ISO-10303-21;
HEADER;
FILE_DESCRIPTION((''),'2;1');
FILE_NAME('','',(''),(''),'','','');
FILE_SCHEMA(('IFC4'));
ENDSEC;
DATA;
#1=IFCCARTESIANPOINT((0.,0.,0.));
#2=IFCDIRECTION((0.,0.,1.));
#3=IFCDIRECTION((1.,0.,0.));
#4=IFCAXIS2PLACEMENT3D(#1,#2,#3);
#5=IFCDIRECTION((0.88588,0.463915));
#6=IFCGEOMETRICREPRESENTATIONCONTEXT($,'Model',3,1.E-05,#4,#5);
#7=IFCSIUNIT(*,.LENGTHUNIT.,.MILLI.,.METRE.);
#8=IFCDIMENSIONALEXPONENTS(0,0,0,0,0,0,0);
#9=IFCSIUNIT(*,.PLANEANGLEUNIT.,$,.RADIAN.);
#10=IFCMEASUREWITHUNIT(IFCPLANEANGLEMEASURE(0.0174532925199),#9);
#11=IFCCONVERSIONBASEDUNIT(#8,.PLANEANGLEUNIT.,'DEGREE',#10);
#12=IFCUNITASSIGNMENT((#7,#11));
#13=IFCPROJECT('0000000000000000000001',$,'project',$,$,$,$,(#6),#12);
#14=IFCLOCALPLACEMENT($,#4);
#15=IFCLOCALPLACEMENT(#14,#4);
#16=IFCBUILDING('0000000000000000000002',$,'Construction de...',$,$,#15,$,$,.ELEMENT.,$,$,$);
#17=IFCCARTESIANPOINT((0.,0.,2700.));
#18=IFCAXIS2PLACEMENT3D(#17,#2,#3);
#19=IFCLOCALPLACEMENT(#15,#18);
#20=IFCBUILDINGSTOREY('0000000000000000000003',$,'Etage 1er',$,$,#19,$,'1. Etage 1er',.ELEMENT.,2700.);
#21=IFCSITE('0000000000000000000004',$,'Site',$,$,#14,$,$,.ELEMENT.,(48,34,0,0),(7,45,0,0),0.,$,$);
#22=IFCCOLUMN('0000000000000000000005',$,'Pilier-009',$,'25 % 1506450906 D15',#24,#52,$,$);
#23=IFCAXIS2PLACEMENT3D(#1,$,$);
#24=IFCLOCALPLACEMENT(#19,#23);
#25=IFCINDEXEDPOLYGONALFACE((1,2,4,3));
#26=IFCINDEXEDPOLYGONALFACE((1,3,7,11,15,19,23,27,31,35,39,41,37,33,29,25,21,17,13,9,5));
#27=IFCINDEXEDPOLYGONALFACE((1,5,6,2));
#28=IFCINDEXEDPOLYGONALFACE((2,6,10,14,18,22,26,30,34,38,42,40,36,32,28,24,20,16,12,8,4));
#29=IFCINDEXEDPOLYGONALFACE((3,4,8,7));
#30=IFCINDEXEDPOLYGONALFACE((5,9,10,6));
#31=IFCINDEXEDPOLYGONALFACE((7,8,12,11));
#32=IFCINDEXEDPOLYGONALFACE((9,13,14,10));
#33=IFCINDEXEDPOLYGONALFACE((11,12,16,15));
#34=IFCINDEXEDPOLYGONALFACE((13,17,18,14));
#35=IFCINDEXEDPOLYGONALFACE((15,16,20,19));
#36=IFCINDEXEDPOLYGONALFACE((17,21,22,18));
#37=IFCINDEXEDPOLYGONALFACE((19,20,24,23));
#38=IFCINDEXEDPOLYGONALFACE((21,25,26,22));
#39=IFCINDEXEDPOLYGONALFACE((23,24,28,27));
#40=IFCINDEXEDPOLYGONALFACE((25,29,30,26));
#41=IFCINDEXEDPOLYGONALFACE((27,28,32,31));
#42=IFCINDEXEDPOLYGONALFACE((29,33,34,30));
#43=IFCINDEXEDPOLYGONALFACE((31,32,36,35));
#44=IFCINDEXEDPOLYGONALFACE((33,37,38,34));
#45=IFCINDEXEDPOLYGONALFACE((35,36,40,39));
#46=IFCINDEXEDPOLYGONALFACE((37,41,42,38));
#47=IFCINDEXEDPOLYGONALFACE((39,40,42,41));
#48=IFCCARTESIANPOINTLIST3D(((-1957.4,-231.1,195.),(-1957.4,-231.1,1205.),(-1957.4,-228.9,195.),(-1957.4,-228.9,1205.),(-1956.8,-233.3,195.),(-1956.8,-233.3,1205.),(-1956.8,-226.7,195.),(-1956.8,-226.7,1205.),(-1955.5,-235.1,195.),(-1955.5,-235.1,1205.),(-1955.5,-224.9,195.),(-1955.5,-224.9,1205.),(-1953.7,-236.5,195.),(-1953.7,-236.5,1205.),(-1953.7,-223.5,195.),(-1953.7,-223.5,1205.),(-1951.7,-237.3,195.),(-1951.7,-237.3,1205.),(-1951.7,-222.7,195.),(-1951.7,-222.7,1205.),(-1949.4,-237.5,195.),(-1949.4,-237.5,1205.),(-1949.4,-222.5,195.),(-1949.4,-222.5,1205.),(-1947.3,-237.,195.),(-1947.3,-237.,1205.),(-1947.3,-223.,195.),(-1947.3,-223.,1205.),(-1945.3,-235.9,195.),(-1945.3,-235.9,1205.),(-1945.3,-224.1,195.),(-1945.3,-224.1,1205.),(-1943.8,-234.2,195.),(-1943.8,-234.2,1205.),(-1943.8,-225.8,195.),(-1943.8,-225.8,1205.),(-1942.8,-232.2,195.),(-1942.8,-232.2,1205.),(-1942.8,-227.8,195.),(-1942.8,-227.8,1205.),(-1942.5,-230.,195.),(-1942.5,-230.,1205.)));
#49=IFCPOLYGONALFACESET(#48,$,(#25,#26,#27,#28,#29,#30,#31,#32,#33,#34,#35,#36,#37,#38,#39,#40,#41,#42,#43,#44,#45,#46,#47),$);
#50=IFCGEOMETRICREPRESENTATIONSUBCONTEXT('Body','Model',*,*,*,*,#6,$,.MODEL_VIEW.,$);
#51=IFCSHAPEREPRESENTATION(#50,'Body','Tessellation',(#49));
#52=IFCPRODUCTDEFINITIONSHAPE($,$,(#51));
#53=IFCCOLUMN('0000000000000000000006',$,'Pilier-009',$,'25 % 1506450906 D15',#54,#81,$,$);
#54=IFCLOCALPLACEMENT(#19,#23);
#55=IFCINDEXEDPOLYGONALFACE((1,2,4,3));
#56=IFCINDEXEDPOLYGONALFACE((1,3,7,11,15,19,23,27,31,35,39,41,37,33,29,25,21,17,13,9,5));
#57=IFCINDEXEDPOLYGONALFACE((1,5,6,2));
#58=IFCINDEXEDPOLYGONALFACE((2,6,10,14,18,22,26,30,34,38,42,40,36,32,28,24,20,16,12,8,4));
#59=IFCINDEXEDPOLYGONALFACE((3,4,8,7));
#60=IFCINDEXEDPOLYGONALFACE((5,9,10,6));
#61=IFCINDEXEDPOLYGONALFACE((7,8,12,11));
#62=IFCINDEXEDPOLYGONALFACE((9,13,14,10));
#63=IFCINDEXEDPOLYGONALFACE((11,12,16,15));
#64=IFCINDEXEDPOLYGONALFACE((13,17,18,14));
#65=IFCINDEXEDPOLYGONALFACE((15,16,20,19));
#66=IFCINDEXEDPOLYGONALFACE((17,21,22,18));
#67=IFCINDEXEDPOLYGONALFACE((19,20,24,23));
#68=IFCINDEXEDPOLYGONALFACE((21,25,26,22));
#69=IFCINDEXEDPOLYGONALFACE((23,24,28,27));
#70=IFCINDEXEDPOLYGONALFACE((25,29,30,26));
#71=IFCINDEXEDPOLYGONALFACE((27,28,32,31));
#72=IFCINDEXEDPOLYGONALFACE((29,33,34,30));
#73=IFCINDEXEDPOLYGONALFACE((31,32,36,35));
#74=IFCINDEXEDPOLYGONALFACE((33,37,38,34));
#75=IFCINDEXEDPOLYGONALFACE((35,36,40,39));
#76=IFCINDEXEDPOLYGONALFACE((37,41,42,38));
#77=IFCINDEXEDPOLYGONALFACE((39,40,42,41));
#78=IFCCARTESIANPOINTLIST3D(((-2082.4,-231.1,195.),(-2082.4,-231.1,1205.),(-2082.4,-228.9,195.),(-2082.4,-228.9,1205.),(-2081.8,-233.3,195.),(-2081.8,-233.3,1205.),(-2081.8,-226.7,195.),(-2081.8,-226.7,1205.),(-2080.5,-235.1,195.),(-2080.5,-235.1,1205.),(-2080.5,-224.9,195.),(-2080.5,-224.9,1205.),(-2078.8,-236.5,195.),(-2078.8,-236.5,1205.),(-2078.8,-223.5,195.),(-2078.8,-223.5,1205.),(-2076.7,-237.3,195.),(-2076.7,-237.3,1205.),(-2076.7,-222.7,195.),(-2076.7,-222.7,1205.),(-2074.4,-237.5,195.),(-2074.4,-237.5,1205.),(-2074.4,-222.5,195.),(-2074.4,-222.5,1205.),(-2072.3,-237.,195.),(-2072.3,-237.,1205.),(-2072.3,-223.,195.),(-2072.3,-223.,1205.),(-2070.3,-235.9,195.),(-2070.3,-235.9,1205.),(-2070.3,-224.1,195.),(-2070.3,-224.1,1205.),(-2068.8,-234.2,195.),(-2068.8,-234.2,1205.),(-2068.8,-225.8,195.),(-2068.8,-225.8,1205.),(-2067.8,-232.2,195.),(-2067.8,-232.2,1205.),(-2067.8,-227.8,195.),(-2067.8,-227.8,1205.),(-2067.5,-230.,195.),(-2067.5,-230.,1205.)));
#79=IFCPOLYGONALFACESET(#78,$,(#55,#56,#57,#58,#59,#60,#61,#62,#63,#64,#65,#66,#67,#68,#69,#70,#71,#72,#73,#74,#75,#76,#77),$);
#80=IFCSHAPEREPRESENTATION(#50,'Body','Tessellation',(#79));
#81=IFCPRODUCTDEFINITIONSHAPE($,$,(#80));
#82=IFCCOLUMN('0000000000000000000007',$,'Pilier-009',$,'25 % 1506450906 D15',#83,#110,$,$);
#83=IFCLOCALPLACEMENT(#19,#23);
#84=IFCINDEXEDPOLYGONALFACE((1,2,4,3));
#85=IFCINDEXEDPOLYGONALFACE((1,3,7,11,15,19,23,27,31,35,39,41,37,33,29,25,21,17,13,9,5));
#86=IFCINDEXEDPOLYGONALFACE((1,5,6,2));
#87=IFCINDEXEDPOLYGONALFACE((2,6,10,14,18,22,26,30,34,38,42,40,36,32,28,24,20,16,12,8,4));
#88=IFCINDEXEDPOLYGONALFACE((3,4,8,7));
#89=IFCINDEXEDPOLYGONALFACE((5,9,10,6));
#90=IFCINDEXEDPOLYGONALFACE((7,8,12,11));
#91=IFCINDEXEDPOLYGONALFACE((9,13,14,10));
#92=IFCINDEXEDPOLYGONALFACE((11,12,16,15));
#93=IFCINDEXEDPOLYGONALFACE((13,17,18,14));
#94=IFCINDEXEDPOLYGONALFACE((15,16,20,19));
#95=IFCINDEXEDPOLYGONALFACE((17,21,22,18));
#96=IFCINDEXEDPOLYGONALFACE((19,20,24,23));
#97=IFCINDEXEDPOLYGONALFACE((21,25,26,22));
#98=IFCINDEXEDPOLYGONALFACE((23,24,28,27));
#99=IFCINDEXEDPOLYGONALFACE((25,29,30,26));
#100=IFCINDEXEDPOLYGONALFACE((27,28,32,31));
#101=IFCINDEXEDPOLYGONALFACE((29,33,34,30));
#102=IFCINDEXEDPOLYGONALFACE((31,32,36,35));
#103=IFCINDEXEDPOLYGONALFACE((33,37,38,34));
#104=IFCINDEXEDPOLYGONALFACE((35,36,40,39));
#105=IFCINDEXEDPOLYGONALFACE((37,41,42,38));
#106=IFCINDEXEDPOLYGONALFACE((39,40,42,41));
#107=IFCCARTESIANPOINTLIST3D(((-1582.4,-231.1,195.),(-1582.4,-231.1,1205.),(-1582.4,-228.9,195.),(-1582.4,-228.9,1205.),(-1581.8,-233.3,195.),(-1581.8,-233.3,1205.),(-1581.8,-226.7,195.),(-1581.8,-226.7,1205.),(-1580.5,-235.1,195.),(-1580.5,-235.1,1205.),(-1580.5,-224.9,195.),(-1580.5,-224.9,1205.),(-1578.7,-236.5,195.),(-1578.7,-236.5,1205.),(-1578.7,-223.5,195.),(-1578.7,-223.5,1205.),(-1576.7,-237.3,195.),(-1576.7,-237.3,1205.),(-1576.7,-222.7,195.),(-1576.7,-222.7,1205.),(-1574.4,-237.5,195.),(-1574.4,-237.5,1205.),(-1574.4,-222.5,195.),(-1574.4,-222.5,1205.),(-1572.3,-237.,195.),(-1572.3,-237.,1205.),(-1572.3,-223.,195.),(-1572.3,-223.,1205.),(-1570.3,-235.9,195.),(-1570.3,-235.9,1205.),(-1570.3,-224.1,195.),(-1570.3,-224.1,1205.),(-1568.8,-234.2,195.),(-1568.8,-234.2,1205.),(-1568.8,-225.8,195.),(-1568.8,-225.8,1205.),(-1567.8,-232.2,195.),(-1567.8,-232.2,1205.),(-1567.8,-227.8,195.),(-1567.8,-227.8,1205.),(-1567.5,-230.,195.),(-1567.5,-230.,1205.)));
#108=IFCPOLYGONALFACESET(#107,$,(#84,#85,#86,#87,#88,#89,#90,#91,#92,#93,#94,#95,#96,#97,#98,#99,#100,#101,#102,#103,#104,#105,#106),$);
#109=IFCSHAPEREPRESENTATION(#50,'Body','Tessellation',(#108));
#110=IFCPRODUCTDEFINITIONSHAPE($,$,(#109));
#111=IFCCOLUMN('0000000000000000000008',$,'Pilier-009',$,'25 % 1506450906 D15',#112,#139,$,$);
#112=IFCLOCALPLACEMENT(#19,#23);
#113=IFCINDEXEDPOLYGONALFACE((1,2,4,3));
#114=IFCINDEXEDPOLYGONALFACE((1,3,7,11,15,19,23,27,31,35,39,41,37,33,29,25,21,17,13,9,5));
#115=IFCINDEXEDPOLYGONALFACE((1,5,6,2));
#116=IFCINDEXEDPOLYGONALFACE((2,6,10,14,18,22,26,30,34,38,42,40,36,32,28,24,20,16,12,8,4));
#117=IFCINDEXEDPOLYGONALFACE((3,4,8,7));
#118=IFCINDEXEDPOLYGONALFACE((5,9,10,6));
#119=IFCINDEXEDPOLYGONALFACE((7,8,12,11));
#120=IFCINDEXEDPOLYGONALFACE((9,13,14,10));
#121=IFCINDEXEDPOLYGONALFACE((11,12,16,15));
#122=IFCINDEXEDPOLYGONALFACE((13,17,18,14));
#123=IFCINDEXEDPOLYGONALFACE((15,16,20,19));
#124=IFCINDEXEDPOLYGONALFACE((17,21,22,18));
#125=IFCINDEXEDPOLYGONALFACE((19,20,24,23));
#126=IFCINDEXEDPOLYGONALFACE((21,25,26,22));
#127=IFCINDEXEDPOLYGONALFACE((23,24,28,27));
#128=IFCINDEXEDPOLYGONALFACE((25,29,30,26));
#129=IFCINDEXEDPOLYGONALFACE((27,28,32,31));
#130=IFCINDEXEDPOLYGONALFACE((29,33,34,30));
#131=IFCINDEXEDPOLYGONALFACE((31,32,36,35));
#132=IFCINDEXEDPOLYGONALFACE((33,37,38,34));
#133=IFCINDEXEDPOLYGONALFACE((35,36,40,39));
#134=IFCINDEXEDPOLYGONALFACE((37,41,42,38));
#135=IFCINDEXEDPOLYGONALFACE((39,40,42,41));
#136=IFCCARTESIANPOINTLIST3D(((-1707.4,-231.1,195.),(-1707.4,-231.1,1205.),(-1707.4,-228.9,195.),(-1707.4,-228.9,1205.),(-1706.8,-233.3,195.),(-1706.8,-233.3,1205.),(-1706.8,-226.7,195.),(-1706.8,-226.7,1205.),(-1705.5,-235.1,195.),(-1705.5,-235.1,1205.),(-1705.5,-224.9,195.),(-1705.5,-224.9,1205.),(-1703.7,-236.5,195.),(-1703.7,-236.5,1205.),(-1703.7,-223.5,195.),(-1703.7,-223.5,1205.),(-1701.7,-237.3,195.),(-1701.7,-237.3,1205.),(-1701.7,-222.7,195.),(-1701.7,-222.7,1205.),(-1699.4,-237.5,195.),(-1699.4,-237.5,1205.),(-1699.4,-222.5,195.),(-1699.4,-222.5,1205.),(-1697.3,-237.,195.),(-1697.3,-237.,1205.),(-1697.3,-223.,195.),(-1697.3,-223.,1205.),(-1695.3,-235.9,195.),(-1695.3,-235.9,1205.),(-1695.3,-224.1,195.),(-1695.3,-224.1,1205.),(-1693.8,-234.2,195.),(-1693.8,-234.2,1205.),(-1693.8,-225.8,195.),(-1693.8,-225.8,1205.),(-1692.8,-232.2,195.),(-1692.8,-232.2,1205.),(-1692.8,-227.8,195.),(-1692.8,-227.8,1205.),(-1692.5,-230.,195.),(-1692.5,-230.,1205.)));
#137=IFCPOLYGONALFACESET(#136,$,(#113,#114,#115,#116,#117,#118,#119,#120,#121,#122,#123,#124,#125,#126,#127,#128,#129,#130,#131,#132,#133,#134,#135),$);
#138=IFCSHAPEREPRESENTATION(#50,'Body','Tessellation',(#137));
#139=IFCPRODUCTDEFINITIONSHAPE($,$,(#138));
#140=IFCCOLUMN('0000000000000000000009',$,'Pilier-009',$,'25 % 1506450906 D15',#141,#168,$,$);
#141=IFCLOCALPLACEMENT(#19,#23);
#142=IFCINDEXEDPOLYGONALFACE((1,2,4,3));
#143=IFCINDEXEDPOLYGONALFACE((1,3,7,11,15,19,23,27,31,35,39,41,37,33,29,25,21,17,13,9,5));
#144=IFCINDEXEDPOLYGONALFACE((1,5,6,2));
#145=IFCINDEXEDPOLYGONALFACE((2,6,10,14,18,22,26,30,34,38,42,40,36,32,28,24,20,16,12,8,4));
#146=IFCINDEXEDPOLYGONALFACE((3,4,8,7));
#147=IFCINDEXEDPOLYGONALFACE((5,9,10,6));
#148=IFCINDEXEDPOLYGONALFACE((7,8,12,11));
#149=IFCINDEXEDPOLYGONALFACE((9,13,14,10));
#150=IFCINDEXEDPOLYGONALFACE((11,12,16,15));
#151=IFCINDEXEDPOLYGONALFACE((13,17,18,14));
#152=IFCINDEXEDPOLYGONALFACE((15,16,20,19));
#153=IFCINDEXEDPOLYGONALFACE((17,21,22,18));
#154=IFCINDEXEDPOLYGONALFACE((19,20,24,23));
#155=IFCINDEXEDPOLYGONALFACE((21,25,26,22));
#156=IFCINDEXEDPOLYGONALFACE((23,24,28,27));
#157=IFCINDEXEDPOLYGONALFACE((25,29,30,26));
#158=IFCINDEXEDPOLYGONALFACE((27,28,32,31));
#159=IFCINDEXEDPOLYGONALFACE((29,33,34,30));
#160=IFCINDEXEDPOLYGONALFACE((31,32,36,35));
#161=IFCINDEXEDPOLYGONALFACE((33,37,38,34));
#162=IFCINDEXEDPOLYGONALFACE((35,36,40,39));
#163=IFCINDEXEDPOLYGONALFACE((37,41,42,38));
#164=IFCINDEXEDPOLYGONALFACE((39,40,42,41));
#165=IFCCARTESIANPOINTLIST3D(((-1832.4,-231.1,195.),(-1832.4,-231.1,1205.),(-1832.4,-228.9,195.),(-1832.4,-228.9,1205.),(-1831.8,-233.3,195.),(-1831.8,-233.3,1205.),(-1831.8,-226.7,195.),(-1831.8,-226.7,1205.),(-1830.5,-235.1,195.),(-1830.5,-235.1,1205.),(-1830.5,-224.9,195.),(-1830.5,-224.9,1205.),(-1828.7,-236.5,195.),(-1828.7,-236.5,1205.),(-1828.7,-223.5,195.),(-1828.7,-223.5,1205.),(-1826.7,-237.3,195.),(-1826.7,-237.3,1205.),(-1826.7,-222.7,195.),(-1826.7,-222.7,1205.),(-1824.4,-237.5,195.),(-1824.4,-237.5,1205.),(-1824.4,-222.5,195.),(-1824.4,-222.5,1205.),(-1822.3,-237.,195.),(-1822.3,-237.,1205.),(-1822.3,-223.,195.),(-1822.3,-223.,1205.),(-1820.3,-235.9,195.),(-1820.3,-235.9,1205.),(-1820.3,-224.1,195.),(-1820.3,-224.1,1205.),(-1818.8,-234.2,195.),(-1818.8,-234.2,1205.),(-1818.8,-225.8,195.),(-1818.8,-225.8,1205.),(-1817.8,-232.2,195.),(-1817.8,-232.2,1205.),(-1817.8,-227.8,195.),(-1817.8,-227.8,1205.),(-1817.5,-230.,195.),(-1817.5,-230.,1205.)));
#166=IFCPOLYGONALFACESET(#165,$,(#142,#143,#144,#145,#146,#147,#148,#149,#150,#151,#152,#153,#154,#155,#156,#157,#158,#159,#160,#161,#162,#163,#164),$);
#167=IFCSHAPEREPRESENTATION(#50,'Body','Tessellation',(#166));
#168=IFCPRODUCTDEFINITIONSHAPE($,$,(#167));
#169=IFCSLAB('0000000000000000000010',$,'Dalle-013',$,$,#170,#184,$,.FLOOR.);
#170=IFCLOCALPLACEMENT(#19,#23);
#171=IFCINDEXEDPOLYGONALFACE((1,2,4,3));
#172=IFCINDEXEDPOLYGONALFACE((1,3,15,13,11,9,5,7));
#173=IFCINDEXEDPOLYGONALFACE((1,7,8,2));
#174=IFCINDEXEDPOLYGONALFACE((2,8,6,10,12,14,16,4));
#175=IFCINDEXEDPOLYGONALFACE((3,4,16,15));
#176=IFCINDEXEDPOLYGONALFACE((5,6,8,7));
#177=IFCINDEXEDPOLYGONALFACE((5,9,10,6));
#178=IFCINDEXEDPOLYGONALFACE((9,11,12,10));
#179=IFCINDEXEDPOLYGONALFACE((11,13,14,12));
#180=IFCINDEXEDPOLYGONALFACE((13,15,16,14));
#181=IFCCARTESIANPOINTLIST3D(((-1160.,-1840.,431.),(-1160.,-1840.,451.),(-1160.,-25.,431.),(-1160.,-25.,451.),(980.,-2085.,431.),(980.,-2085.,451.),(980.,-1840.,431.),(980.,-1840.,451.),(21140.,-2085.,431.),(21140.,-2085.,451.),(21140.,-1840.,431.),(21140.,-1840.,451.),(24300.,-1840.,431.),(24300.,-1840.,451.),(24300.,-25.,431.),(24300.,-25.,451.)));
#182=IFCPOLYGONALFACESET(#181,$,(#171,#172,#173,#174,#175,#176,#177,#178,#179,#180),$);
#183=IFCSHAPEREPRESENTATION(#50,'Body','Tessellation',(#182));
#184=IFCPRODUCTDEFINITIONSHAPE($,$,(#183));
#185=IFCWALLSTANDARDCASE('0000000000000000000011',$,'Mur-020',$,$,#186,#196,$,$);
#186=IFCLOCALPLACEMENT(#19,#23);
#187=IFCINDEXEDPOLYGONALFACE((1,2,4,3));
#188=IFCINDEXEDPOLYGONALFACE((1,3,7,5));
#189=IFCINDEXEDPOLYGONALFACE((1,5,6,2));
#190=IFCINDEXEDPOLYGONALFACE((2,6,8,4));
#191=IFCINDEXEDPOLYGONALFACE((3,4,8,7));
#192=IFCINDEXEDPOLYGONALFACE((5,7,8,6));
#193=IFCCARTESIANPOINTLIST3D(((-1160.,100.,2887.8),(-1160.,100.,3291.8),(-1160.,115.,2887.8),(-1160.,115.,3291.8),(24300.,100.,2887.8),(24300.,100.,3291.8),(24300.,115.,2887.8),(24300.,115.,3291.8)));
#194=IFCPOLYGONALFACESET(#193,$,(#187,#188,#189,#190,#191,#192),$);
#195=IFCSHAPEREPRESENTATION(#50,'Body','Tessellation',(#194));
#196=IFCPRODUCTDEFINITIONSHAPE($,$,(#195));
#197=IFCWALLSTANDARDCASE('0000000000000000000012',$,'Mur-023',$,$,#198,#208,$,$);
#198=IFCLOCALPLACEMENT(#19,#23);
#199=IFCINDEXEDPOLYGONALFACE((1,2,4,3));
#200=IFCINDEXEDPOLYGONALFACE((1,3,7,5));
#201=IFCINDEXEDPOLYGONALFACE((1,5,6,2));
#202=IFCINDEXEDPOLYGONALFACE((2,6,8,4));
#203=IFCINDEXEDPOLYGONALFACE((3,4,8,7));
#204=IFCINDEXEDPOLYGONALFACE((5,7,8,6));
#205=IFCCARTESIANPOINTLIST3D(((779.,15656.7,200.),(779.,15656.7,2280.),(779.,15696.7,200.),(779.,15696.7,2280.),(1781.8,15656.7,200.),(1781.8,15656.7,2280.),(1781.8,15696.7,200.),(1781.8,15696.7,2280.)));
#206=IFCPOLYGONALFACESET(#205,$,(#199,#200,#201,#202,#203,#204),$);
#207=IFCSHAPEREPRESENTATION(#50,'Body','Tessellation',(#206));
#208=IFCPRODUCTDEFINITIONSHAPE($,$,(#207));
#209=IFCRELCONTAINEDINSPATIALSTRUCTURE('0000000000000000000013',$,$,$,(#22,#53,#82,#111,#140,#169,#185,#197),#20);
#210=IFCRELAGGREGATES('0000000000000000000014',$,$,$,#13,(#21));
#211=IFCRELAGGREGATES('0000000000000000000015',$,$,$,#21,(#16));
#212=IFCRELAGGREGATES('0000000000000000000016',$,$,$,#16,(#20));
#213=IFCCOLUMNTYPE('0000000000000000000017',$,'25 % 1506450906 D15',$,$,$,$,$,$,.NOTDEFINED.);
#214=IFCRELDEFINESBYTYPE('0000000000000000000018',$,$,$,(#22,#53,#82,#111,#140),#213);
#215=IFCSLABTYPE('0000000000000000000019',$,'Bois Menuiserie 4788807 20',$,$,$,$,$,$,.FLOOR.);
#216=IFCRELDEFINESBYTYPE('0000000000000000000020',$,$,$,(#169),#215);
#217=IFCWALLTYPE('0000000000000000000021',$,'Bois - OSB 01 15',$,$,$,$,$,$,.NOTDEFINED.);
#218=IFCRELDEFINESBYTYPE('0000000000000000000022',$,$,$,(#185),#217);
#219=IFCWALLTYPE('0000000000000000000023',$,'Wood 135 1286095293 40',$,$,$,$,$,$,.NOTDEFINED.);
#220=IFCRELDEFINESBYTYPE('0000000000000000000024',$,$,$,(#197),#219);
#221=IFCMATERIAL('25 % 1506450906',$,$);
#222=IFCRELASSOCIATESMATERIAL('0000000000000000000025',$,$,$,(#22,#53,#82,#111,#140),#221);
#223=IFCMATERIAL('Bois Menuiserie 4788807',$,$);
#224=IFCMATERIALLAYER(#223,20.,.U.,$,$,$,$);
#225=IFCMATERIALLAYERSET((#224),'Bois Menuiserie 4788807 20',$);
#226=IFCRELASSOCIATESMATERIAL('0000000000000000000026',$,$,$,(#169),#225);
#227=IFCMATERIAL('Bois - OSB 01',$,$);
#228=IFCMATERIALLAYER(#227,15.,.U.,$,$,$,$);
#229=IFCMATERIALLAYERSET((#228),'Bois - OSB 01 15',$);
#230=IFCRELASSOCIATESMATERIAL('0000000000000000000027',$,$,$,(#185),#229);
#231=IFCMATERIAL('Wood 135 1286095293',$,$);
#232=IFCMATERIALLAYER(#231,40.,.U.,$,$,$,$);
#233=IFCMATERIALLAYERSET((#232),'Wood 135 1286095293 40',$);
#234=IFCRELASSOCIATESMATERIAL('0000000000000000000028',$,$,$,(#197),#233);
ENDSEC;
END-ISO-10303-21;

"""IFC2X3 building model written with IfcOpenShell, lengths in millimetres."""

from ifc_helpers import new_model, entity, si_unit, converted_unit, direction, frame, origin_with_axes, origin_2d_with_axis, place, context, subcontext, project, spatial, polyline, circle, outline, extrude, material, layer, layer_set, layer_usage, type_object, element, save


model = new_model("IFC2X3")

# Units and contexts
model_context = context("Model", 3, precision=1e-05, world=origin_with_axes(), true_north=direction((0.88588, 0.463915)))
body_context = subcontext(model_context, "Body", "Model", "MODEL_VIEW")
ifc_project = project(units=[si_unit("LENGTHUNIT", "METRE", prefix="MILLI"), converted_unit("PLANEANGLEUNIT", "DEGREE", entity("IfcPlaneAngleMeasure", 0.0174532925199), si_unit("PLANEANGLEUNIT", "RADIAN"), dimensions=[0, 0, 0, 0, 0, 0, 0])], contexts=[model_context])

# Site, building, storey
site_placement = place(None, origin_with_axes())
site = spatial("IfcSite", under=ifc_project, at=site_placement, Name="Site", CompositionType="ELEMENT", RefLatitude=(48, 34, 0, 0), RefLongitude=(7, 45, 0, 0), RefElevation=0.0)
building_placement = place(site_placement, origin_with_axes())
building = spatial("IfcBuilding", under=site, at=building_placement, Name="Construction de...", CompositionType="ELEMENT")
storey_placement = place(building_placement, frame((0.0, 0.0, 2700.0), z_axis=(0.0, 0.0, 1.0), x_axis=(1.0, 0.0, 0.0)))
storey = spatial("IfcBuildingStorey", under=building, at=storey_placement, Name="Etage 1er", LongName="1. Etage 1er", CompositionType="ELEMENT", Elevation=2700.0)

# Columns
ifc_material_1 = material(Name="25 % 1506450906")
column_type = type_object("IfcColumnType", Name="25 % 1506450906 D15", PredefinedType="NOTDEFINED")
for number, where, z_axis, x_axis, name in (
    (1, (-1950.0, -230.0, 195.0), (0.0, 0.0, 1.0), (1.0, 0.0, 0.0), "Pilier-009"),
    (2, (-2075.0, -230.0, 195.0), (0.0, 0.0, 1.0), (1.0, 0.0, 0.0), "Pilier-009"),
    (3, (-1575.0, -230.0, 195.0), (0.0, 0.0, 1.0), (1.0, 0.0, 0.0), "Pilier-009"),
    (4, (-1700.0, -230.0, 195.0), (0.0, 0.0, 1.0), (1.0, 0.0, 0.0), "Pilier-009"),
    (5, (-1825.0, -230.0, 195.0), (0.0, 0.0, 1.0), (1.0, 0.0, 0.0), "Pilier-009"),
):
    element("IfcColumn", number, at=place(storey_placement, frame(where, z_axis=z_axis, x_axis=x_axis)), inside=storey, type_object=column_type, material=ifc_material_1, Name=name, ObjectType="25 % 1506450906 D15", context=body_context, shape_type="SweptSolid", body=[
        extrude(circle(Radius=7.5, at=origin_2d_with_axis()), origin_with_axes(), (0.0, 0.0, 1.0), 1010.0),
    ])

# Slab
ifc_material_2 = material(Name="Bois Menuiserie 4788807")
ifc_layer_1 = layer(ifc_material_2, 20.0, ventilated="UNKNOWN")
ifc_layer_set_1 = layer_set([ifc_layer_1], Name="Bois Menuiserie 4788807 20")
ifc_layer_usage_1 = layer_usage(ifc_layer_set_1, "AXIS3", "NEGATIVE", 20.0)
slab_type_1 = type_object("IfcSlabType", Name="Bois Menuiserie 4788807 20", PredefinedType="FLOOR")
slab_1_placement = place(storey_placement, frame((-1160.0, -25.0, 451.0), z_axis=(0.0, 0.0, 1.0), x_axis=(1.0, 0.0, 0.0)))
element("IfcSlab", 6, at=slab_1_placement, inside=storey, type_object=slab_type_1, material=ifc_layer_usage_1, Name="Dalle-013", PredefinedType="FLOOR", context=body_context, shape_type="SweptSolid", body=[
    extrude(outline(polyline([(0.0, 0.0), (0.0, -1815.0), (2140.0, -1815.0), (2140.0, -2060.0), (22300.0, -2060.0), (22300.0, -1815.0), (25460.0, -1815.0), (25460.0, 0.0), (0.0, 0.0)])), frame((0.0, 0.0, -20.0), z_axis=(0.0, 0.0, 1.0), x_axis=(1.0, 0.0, 0.0)), (0.0, 0.0, 1.0), 20.0),
])

# Walls
ifc_material_3 = material(Name="Bois - OSB 01")
ifc_layer_2 = layer(ifc_material_3, 15.0, ventilated="UNKNOWN")
ifc_layer_set_2 = layer_set([ifc_layer_2], Name="Bois - OSB 01 15")
ifc_layer_usage_2 = layer_usage(ifc_layer_set_2, "AXIS2", "NEGATIVE", 7.5)
wall_type_1 = type_object("IfcWallType", Name="Bois - OSB 01 15", PredefinedType="NOTDEFINED")
wall_1_placement = place(storey_placement, frame((-1160.0, 107.5, 2887.8), z_axis=(0.0, 0.0, 1.0), x_axis=(1.0, 0.0, 0.0)))
element("IfcWallStandardCase", 7, at=wall_1_placement, inside=storey, type_object=wall_type_1, material=ifc_layer_usage_2, Name="Mur-020", context=body_context, shape_type="SweptSolid", body=[
    extrude(outline(polyline([(0.0, -7.5), (25460.0, -7.5), (25460.0, 7.5), (0.0, 7.5), (0.0, -7.5)])), origin_with_axes(), (0.0, 0.0, 1.0), 404.0),
])
ifc_material_4 = material(Name="Wood 135 1286095293")
ifc_layer_3 = layer(ifc_material_4, 40.0, ventilated="UNKNOWN")
ifc_layer_set_3 = layer_set([ifc_layer_3], Name="Wood 135 1286095293 40")
ifc_layer_usage_3 = layer_usage(ifc_layer_set_3, "AXIS2", "NEGATIVE", 20.0)
wall_type_2 = type_object("IfcWallType", Name="Wood 135 1286095293 40", PredefinedType="NOTDEFINED")
wall_2_placement = place(storey_placement, frame((779.0, 15676.7, 200.0), z_axis=(0.0, 0.0, 1.0), x_axis=(1.0, 0.0, 0.0)))
element("IfcWallStandardCase", 8, at=wall_2_placement, inside=storey, type_object=wall_type_2, material=ifc_layer_usage_3, Name="Mur-023", context=body_context, shape_type="SweptSolid", body=[
    extrude(outline(polyline([(0.0, -20.0), (1002.8, -20.0), (1002.8, 20.0), (0.0, 20.0), (0.0, -20.0)])), origin_with_axes(), (0.0, 0.0, 1.0), 2080.0),
])

save(model, "model.ifc")
